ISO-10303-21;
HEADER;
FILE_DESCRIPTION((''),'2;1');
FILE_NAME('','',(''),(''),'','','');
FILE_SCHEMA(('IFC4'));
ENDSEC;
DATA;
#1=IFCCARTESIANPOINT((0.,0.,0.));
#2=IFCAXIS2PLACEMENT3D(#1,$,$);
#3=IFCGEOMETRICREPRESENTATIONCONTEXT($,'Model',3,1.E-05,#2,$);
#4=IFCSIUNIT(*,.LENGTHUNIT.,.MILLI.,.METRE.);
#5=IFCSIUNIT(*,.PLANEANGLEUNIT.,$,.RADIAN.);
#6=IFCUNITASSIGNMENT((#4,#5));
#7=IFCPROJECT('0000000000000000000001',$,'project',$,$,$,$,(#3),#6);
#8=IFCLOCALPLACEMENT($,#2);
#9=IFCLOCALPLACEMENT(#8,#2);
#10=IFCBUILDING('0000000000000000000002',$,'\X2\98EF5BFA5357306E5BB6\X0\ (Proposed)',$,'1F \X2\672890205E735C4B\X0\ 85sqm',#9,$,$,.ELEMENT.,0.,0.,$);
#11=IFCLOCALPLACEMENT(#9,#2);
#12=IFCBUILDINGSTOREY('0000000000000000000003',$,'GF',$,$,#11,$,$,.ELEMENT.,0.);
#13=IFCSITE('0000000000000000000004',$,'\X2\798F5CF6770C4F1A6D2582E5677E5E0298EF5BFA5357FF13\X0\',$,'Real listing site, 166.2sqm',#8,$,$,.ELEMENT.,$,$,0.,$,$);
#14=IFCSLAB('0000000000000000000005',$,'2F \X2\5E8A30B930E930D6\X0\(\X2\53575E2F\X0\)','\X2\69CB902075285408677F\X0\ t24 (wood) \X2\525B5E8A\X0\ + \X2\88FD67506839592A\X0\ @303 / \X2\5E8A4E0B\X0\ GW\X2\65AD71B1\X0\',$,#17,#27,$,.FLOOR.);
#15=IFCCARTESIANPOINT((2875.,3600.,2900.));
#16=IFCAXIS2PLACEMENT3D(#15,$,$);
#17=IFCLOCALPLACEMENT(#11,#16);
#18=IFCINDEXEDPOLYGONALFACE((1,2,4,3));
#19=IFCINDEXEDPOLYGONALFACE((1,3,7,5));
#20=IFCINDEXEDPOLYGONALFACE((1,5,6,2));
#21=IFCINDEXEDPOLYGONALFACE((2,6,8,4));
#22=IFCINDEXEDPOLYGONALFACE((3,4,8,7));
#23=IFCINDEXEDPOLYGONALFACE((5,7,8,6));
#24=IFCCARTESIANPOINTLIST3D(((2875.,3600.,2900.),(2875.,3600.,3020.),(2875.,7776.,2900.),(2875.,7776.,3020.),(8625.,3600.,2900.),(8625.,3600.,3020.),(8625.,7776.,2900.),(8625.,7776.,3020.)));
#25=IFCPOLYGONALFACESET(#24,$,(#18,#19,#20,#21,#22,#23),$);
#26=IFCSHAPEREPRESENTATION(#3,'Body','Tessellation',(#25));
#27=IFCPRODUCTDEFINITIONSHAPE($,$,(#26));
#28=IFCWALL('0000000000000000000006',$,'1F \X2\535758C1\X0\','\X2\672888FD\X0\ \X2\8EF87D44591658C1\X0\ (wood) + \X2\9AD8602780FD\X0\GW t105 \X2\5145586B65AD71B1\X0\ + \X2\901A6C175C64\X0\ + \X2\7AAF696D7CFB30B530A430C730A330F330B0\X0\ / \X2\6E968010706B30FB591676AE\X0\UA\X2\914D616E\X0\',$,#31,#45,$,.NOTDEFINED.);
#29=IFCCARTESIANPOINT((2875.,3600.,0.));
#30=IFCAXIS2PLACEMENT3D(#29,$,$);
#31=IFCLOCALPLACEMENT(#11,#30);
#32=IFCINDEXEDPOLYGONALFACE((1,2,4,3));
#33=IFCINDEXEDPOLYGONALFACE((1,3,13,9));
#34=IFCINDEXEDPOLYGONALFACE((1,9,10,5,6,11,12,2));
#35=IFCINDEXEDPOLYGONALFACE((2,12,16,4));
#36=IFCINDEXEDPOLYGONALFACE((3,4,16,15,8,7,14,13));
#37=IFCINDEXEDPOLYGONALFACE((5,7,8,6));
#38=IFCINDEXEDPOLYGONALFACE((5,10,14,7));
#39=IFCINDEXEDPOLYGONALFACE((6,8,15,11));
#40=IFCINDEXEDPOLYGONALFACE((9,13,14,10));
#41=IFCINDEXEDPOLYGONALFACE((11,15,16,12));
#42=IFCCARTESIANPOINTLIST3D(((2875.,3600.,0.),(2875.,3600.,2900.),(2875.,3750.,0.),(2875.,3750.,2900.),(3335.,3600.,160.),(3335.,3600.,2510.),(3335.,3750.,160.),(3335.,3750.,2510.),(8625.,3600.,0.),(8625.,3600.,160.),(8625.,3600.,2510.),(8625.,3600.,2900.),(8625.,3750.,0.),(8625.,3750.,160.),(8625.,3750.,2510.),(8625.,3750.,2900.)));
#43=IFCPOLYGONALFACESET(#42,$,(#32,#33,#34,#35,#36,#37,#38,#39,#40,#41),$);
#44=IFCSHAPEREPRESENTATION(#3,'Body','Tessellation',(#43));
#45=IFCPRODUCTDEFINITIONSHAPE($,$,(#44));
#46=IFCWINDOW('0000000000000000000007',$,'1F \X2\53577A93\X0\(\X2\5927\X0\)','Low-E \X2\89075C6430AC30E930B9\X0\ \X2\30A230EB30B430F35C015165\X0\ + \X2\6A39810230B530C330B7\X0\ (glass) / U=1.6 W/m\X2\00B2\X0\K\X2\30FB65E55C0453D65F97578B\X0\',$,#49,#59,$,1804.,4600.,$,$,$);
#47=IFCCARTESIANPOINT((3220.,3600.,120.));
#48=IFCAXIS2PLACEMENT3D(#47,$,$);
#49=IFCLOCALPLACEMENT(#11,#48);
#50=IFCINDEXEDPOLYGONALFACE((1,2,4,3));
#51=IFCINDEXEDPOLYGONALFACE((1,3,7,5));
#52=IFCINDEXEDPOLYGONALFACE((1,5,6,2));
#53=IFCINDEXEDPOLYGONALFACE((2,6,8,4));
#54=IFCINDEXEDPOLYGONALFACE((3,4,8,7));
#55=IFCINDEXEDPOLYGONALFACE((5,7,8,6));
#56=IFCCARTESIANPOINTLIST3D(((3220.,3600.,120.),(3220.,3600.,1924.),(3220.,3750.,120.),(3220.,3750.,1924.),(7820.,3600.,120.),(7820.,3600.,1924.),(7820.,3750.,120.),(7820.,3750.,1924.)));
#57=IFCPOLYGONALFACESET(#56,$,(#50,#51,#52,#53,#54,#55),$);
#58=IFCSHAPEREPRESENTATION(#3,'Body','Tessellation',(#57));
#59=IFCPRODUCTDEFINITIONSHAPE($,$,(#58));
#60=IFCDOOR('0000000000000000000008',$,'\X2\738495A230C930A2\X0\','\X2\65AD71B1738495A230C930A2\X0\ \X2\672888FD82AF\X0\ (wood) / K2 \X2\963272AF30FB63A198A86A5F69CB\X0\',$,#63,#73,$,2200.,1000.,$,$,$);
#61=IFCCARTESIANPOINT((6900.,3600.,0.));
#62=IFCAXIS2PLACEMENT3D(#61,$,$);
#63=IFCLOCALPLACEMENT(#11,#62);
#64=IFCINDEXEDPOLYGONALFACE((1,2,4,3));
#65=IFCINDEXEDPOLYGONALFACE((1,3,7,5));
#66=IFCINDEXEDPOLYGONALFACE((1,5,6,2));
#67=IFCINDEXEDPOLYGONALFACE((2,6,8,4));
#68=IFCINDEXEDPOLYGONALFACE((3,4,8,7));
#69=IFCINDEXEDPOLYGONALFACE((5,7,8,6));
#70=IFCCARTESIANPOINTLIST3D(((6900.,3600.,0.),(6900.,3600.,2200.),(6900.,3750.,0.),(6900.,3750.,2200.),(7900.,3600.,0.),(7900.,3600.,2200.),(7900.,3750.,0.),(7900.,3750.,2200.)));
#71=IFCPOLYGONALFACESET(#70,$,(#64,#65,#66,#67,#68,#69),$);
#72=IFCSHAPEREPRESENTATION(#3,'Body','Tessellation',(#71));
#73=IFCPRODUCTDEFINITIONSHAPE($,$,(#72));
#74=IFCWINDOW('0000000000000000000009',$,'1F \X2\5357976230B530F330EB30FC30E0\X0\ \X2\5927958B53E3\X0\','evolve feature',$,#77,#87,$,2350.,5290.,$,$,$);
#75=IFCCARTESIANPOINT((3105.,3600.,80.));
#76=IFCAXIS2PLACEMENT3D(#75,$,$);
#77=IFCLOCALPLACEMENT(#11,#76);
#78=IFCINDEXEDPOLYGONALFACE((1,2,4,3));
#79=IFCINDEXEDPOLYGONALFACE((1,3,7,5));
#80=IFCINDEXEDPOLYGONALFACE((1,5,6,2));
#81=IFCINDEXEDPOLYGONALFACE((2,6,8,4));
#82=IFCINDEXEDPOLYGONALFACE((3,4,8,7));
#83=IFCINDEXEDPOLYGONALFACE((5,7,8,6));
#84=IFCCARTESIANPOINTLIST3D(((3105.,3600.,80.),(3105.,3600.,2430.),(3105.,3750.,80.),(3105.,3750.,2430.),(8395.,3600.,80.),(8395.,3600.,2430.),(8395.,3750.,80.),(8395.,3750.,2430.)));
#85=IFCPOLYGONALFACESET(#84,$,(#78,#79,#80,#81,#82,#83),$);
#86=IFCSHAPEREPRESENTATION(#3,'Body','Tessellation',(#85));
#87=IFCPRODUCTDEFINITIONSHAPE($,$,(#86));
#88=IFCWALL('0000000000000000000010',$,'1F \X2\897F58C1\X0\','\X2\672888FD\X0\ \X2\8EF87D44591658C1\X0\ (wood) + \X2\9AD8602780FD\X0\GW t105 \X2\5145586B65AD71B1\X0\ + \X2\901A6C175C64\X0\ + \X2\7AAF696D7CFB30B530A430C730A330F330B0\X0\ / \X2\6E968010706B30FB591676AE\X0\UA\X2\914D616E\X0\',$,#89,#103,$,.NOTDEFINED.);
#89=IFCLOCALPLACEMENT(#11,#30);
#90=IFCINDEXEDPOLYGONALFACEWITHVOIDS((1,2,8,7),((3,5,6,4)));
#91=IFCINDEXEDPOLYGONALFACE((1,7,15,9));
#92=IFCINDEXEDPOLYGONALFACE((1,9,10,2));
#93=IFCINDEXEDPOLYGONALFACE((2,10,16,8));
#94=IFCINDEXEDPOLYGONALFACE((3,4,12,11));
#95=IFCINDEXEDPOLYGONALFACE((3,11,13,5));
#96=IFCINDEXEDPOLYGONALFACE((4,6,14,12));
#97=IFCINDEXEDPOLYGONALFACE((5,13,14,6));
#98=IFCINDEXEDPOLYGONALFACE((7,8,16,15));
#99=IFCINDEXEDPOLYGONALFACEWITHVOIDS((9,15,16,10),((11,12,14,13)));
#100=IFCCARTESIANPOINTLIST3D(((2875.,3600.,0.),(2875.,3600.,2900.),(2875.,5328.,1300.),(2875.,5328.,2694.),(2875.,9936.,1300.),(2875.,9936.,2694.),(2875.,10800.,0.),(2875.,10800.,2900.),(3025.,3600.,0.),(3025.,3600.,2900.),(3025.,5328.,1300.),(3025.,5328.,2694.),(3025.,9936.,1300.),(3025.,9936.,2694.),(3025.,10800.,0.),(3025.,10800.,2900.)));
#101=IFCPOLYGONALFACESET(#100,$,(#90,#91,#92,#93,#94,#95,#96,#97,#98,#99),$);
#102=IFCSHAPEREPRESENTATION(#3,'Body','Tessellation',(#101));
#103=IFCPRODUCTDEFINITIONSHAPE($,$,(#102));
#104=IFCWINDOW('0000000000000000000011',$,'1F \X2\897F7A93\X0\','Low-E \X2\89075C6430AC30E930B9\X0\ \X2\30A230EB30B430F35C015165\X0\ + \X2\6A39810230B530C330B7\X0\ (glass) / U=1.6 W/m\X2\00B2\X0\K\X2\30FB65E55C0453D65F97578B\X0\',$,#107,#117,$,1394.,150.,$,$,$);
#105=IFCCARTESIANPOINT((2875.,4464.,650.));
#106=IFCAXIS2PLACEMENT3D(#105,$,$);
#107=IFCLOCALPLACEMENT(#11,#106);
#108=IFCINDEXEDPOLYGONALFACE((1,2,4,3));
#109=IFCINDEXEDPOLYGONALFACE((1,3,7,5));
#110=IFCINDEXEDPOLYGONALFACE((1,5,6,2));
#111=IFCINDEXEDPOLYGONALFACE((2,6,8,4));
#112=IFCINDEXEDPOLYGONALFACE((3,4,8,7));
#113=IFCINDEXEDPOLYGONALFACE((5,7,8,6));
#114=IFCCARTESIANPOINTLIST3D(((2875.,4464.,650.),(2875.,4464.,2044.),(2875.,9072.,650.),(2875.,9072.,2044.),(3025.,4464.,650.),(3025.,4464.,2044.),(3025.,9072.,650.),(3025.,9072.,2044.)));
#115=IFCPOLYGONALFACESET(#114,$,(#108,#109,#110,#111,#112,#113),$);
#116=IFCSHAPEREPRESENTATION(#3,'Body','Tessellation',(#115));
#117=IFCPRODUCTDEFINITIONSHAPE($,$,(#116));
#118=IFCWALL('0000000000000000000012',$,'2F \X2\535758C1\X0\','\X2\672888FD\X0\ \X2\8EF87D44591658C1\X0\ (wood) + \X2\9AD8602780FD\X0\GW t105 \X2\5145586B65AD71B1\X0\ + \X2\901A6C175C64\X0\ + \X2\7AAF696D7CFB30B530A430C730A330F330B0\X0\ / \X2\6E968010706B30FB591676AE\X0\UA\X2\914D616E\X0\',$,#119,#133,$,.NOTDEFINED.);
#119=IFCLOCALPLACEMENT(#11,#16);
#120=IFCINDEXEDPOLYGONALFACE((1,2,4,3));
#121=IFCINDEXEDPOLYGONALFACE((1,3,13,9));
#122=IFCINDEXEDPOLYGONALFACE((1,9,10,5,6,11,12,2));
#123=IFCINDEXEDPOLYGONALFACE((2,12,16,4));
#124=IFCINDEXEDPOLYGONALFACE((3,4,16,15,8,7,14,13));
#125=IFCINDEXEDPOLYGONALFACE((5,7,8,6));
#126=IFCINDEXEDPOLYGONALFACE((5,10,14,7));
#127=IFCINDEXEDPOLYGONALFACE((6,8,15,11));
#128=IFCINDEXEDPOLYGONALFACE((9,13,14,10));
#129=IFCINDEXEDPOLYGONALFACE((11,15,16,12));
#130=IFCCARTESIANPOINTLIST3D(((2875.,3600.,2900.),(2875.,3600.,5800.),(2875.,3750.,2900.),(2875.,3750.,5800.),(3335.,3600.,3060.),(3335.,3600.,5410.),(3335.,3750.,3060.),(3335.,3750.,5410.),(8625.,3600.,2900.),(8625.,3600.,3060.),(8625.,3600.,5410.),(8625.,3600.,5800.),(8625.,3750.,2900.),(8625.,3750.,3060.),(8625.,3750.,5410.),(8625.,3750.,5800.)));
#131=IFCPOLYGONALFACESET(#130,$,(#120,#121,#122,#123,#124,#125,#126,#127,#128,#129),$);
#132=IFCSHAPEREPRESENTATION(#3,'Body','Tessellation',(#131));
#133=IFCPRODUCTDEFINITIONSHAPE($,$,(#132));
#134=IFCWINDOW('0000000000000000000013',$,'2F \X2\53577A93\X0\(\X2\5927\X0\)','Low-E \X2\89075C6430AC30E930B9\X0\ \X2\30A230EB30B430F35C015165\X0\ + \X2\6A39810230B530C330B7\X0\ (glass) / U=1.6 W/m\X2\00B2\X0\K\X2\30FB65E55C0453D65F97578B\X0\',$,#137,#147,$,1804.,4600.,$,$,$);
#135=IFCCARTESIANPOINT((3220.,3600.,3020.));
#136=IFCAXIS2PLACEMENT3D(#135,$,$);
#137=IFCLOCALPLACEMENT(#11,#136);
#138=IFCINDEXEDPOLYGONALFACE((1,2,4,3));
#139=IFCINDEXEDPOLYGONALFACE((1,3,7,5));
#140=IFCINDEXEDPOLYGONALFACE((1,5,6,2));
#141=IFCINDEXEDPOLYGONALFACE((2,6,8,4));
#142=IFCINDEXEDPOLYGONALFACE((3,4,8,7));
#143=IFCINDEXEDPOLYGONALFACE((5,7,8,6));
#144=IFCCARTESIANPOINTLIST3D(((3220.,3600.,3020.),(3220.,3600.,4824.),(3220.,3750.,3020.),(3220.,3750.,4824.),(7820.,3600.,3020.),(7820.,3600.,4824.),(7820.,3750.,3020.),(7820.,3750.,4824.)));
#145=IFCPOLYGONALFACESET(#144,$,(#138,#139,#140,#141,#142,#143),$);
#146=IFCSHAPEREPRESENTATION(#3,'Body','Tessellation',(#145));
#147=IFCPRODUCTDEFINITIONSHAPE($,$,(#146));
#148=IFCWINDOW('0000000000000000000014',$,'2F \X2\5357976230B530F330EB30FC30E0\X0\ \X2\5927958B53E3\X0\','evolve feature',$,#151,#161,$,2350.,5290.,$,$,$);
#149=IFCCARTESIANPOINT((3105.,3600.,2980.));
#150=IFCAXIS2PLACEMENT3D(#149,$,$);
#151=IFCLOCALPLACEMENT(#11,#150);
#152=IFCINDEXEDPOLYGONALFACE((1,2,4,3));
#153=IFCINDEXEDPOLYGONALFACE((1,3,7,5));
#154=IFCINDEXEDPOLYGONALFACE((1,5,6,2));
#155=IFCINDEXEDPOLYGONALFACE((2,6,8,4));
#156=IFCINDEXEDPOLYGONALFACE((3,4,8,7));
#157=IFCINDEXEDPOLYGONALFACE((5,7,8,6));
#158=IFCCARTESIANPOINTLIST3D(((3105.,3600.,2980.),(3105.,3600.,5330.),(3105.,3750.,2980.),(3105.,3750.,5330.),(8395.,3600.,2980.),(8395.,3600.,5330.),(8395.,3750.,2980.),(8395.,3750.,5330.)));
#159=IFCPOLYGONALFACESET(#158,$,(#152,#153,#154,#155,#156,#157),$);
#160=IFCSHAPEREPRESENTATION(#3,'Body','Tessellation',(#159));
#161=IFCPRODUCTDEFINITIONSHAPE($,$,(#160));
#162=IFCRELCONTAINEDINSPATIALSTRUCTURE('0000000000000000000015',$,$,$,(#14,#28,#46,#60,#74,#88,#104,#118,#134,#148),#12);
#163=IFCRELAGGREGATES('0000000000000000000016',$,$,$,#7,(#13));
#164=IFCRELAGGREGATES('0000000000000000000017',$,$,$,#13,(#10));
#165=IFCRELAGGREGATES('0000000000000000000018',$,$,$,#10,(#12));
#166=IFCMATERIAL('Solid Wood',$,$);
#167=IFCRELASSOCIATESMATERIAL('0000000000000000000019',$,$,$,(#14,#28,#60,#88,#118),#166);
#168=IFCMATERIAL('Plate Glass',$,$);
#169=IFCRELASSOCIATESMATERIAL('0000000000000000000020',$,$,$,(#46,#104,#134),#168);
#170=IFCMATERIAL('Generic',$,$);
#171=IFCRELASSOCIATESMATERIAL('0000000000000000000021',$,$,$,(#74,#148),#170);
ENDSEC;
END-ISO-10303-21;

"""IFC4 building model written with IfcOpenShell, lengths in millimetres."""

from ifc_helpers import new_model, si_unit, frame, frame_2d, origin, place, context, project, spatial, rectangle, extrude, material, element, fill, save


model = new_model("IFC4")

# Units and contexts
model_context = context("Model", 3, precision=1e-05, world=origin())
ifc_project = project(units=[si_unit("LENGTHUNIT", "METRE", prefix="MILLI"), si_unit("PLANEANGLEUNIT", "RADIAN")], contexts=[model_context])

# Site, building, storey
site_placement = place(None, origin())
site = spatial("IfcSite", under=ifc_project, at=site_placement, Name="福島県会津若松市飯寺南３", ObjectType="Real listing site, 166.2sqm", CompositionType="ELEMENT", RefElevation=0.0)
building_placement = place(site_placement, origin())
building = spatial("IfcBuilding", under=site, at=building_placement, Name="飯寺南の家 (Proposed)", ObjectType="1F 木造平屋 85sqm", CompositionType="ELEMENT", ElevationOfRefHeight=0.0, ElevationOfTerrain=0.0)
storey_placement = place(building_placement, origin())
storey = spatial("IfcBuildingStorey", under=building, at=storey_placement, Name="GF", CompositionType="ELEMENT", Elevation=0.0)

# Slab
ifc_material_1 = material(Name="Solid Wood")
slab_1_placement = place(storey_placement, frame((2875.0, 3600.0, 2900.0)))
element("IfcSlab", 1, at=slab_1_placement, inside=storey, material=ifc_material_1, Name="2F 床スラブ(南帯)", Description="構造用合板 t24 (wood) 剛床 + 製材根太 @303 / 床下 GW断熱", PredefinedType="FLOOR", context=model_context, shape_type="SweptSolid", body=[
    extrude(rectangle(XDim=5750.0, YDim=4176.0, at=frame_2d((2875.0, 2088.0))), frame((2875.0, 3600.0, 2900.0)), (0.0, 0.0, 1.0), 120.0),
])
ifc_material_2 = material(Name="Generic")

# Wall, openings, windows, door
wall_1_placement = place(storey_placement, frame((2875.0, 3600.0, 0.0)))
wall_1 = element("IfcWall", 2, at=wall_1_placement, inside=storey, material=ifc_material_1, Name="1F 南壁", Description="木製 軸組外壁 (wood) + 高性能GW t105 充填断熱 + 通気層 + 窯業系サイディング / 準耐火・外皮UA配慮", PredefinedType="NOTDEFINED", context=model_context, shape_type="SweptSolid", body=[
    extrude(rectangle(XDim=5750.0, YDim=150.0, at=frame_2d((2875.0, 75.0))), frame((2875.0, 3600.0, 0.0)), (0.0, 0.0, 1.0), 2900.0),
])
opening_1_placement = place(storey_placement, frame((3220.0, 3600.0, 120.0)))
opening_1 = element("IfcOpeningElement", 3, at=opening_1_placement, cuts=wall_1, PredefinedType="NOTDEFINED", context=model_context, shape_type="SweptSolid", body=[
    extrude(rectangle(XDim=4600.0, YDim=150.0, at=frame_2d((2300.0, 75.0))), frame((3220.0, 3600.0, 120.0)), (0.0, 0.0, 1.0), 1804.0),
])
opening_2_placement = place(storey_placement, frame((6900.0, 3600.0, 0.0)))
opening_2 = element("IfcOpeningElement", 4, at=opening_2_placement, cuts=wall_1, PredefinedType="NOTDEFINED", context=model_context, shape_type="SweptSolid", body=[
    extrude(rectangle(XDim=1000.0, YDim=150.0, at=frame_2d((500.0, 75.0))), frame((6900.0, 3600.0, 0.0)), (0.0, 0.0, 1.0), 2200.0),
])
opening_3_placement = place(storey_placement, frame((3105.0, 3600.0, 80.0)))
opening_3 = element("IfcOpeningElement", 5, at=opening_3_placement, cuts=wall_1, PredefinedType="NOTDEFINED", context=model_context, shape_type="SweptSolid", body=[
    extrude(rectangle(XDim=5290.0, YDim=150.0, at=frame_2d((2645.0, 75.0))), frame((3105.0, 3600.0, 80.0)), (0.0, 0.0, 1.0), 2350.0),
])
ifc_material_3 = material(Name="Plate Glass")
window_1_placement = place(storey_placement, frame((3220.0, 3600.0, 120.0)))
window_1 = element("IfcWindow", 6, at=window_1_placement, inside=storey, material=ifc_material_3, Name="1F 南窓(大)", Description="Low-E 複層ガラス アルゴン封入 + 樹脂サッシ (glass) / U=1.6 W/m²K・日射取得型", OverallHeight=1804.0, OverallWidth=4600.0, context=model_context, shape_type="SweptSolid", body=[
    extrude(rectangle(XDim=4600.0, YDim=150.0, at=frame_2d((2300.0, 75.0))), frame((3220.0, 3600.0, 120.0)), (0.0, 0.0, 1.0), 1804.0),
])
fill(opening_1, window_1)
door_placement = place(storey_placement, frame((6900.0, 3600.0, 0.0)))
door = element("IfcDoor", 7, at=door_placement, inside=storey, material=ifc_material_1, Name="玄関ドア", Description="断熱玄関ドア 木製芯 (wood) / K2 防犯・採風機構", OverallHeight=2200.0, OverallWidth=1000.0, context=model_context, shape_type="SweptSolid", body=[
    extrude(rectangle(XDim=1000.0, YDim=150.0, at=frame_2d((500.0, 75.0))), frame((6900.0, 3600.0, 0.0)), (0.0, 0.0, 1.0), 2200.0),
])
fill(opening_2, door)
window_2_placement = place(storey_placement, frame((3105.0, 3600.0, 80.0)))
window_2 = element("IfcWindow", 8, at=window_2_placement, inside=storey, material=ifc_material_2, Name="1F 南面サンルーム 大開口", Description="evolve feature", OverallHeight=2350.0, OverallWidth=5290.0, context=model_context, shape_type="SweptSolid", body=[
    extrude(rectangle(XDim=5290.0, YDim=150.0, at=frame_2d((2645.0, 75.0))), frame((3105.0, 3600.0, 80.0)), (0.0, 0.0, 1.0), 2350.0),
])
fill(opening_3, window_2)

# Wall, opening, window
wall_2_placement = place(storey_placement, frame((2875.0, 3600.0, 0.0)))
wall_2 = element("IfcWall", 9, at=wall_2_placement, inside=storey, material=ifc_material_1, Name="1F 西壁", Description="木製 軸組外壁 (wood) + 高性能GW t105 充填断熱 + 通気層 + 窯業系サイディング / 準耐火・外皮UA配慮", PredefinedType="NOTDEFINED", context=model_context, shape_type="SweptSolid", body=[
    extrude(rectangle(XDim=150.0, YDim=7200.0, at=frame_2d((75.0, 3600.0))), frame((2875.0, 3600.0, 0.0)), (0.0, 0.0, 1.0), 2900.0),
])
opening_4_placement = place(storey_placement, frame((2875.0, 4464.0, 650.0)))
opening_4 = element("IfcOpeningElement", 10, at=opening_4_placement, cuts=wall_2, PredefinedType="NOTDEFINED", context=model_context, shape_type="SweptSolid", body=[
    extrude(rectangle(XDim=150.0, YDim=4608.0, at=frame_2d((75.0, 2304.0))), frame((2875.0, 4464.0, 650.0)), (0.0, 0.0, 1.0), 1394.0),
])
window_3_placement = place(storey_placement, frame((2875.0, 4464.0, 650.0)))
window_3 = element("IfcWindow", 11, at=window_3_placement, inside=storey, material=ifc_material_3, Name="1F 西窓", Description="Low-E 複層ガラス アルゴン封入 + 樹脂サッシ (glass) / U=1.6 W/m²K・日射取得型", OverallHeight=1394.0, OverallWidth=150.0, context=model_context, shape_type="SweptSolid", body=[
    extrude(rectangle(XDim=150.0, YDim=4608.0, at=frame_2d((75.0, 2304.0))), frame((2875.0, 4464.0, 650.0)), (0.0, 0.0, 1.0), 1394.0),
])
fill(opening_4, window_3)

# Wall, openings, windows
wall_3_placement = place(storey_placement, frame((2875.0, 3600.0, 2900.0)))
wall_3 = element("IfcWall", 12, at=wall_3_placement, inside=storey, material=ifc_material_1, Name="2F 南壁", Description="木製 軸組外壁 (wood) + 高性能GW t105 充填断熱 + 通気層 + 窯業系サイディング / 準耐火・外皮UA配慮", PredefinedType="NOTDEFINED", context=model_context, shape_type="SweptSolid", body=[
    extrude(rectangle(XDim=5750.0, YDim=150.0, at=frame_2d((2875.0, 75.0))), frame((2875.0, 3600.0, 2900.0)), (0.0, 0.0, 1.0), 2900.0),
])
opening_5_placement = place(storey_placement, frame((3220.0, 3600.0, 3020.0)))
opening_5 = element("IfcOpeningElement", 13, at=opening_5_placement, cuts=wall_3, PredefinedType="NOTDEFINED", context=model_context, shape_type="SweptSolid", body=[
    extrude(rectangle(XDim=4600.0, YDim=150.0, at=frame_2d((2300.0, 75.0))), frame((3220.0, 3600.0, 3020.0)), (0.0, 0.0, 1.0), 1804.0),
])
opening_6_placement = place(storey_placement, frame((3105.0, 3600.0, 2980.0)))
opening_6 = element("IfcOpeningElement", 14, at=opening_6_placement, cuts=wall_3, PredefinedType="NOTDEFINED", context=model_context, shape_type="SweptSolid", body=[
    extrude(rectangle(XDim=5290.0, YDim=150.0, at=frame_2d((2645.0, 75.0))), frame((3105.0, 3600.0, 2980.0)), (0.0, 0.0, 1.0), 2350.0),
])
window_4_placement = place(storey_placement, frame((3220.0, 3600.0, 3020.0)))
window_4 = element("IfcWindow", 15, at=window_4_placement, inside=storey, material=ifc_material_3, Name="2F 南窓(大)", Description="Low-E 複層ガラス アルゴン封入 + 樹脂サッシ (glass) / U=1.6 W/m²K・日射取得型", OverallHeight=1804.0, OverallWidth=4600.0, context=model_context, shape_type="SweptSolid", body=[
    extrude(rectangle(XDim=4600.0, YDim=150.0, at=frame_2d((2300.0, 75.0))), frame((3220.0, 3600.0, 3020.0)), (0.0, 0.0, 1.0), 1804.0),
])
fill(opening_5, window_4)
window_5_placement = place(storey_placement, frame((3105.0, 3600.0, 2980.0)))
window_5 = element("IfcWindow", 16, at=window_5_placement, inside=storey, material=ifc_material_2, Name="2F 南面サンルーム 大開口", Description="evolve feature", OverallHeight=2350.0, OverallWidth=5290.0, context=model_context, shape_type="SweptSolid", body=[
    extrude(rectangle(XDim=5290.0, YDim=150.0, at=frame_2d((2645.0, 75.0))), frame((3105.0, 3600.0, 2980.0)), (0.0, 0.0, 1.0), 2350.0),
])
fill(opening_6, window_5)

save(model, "model.ifc")
